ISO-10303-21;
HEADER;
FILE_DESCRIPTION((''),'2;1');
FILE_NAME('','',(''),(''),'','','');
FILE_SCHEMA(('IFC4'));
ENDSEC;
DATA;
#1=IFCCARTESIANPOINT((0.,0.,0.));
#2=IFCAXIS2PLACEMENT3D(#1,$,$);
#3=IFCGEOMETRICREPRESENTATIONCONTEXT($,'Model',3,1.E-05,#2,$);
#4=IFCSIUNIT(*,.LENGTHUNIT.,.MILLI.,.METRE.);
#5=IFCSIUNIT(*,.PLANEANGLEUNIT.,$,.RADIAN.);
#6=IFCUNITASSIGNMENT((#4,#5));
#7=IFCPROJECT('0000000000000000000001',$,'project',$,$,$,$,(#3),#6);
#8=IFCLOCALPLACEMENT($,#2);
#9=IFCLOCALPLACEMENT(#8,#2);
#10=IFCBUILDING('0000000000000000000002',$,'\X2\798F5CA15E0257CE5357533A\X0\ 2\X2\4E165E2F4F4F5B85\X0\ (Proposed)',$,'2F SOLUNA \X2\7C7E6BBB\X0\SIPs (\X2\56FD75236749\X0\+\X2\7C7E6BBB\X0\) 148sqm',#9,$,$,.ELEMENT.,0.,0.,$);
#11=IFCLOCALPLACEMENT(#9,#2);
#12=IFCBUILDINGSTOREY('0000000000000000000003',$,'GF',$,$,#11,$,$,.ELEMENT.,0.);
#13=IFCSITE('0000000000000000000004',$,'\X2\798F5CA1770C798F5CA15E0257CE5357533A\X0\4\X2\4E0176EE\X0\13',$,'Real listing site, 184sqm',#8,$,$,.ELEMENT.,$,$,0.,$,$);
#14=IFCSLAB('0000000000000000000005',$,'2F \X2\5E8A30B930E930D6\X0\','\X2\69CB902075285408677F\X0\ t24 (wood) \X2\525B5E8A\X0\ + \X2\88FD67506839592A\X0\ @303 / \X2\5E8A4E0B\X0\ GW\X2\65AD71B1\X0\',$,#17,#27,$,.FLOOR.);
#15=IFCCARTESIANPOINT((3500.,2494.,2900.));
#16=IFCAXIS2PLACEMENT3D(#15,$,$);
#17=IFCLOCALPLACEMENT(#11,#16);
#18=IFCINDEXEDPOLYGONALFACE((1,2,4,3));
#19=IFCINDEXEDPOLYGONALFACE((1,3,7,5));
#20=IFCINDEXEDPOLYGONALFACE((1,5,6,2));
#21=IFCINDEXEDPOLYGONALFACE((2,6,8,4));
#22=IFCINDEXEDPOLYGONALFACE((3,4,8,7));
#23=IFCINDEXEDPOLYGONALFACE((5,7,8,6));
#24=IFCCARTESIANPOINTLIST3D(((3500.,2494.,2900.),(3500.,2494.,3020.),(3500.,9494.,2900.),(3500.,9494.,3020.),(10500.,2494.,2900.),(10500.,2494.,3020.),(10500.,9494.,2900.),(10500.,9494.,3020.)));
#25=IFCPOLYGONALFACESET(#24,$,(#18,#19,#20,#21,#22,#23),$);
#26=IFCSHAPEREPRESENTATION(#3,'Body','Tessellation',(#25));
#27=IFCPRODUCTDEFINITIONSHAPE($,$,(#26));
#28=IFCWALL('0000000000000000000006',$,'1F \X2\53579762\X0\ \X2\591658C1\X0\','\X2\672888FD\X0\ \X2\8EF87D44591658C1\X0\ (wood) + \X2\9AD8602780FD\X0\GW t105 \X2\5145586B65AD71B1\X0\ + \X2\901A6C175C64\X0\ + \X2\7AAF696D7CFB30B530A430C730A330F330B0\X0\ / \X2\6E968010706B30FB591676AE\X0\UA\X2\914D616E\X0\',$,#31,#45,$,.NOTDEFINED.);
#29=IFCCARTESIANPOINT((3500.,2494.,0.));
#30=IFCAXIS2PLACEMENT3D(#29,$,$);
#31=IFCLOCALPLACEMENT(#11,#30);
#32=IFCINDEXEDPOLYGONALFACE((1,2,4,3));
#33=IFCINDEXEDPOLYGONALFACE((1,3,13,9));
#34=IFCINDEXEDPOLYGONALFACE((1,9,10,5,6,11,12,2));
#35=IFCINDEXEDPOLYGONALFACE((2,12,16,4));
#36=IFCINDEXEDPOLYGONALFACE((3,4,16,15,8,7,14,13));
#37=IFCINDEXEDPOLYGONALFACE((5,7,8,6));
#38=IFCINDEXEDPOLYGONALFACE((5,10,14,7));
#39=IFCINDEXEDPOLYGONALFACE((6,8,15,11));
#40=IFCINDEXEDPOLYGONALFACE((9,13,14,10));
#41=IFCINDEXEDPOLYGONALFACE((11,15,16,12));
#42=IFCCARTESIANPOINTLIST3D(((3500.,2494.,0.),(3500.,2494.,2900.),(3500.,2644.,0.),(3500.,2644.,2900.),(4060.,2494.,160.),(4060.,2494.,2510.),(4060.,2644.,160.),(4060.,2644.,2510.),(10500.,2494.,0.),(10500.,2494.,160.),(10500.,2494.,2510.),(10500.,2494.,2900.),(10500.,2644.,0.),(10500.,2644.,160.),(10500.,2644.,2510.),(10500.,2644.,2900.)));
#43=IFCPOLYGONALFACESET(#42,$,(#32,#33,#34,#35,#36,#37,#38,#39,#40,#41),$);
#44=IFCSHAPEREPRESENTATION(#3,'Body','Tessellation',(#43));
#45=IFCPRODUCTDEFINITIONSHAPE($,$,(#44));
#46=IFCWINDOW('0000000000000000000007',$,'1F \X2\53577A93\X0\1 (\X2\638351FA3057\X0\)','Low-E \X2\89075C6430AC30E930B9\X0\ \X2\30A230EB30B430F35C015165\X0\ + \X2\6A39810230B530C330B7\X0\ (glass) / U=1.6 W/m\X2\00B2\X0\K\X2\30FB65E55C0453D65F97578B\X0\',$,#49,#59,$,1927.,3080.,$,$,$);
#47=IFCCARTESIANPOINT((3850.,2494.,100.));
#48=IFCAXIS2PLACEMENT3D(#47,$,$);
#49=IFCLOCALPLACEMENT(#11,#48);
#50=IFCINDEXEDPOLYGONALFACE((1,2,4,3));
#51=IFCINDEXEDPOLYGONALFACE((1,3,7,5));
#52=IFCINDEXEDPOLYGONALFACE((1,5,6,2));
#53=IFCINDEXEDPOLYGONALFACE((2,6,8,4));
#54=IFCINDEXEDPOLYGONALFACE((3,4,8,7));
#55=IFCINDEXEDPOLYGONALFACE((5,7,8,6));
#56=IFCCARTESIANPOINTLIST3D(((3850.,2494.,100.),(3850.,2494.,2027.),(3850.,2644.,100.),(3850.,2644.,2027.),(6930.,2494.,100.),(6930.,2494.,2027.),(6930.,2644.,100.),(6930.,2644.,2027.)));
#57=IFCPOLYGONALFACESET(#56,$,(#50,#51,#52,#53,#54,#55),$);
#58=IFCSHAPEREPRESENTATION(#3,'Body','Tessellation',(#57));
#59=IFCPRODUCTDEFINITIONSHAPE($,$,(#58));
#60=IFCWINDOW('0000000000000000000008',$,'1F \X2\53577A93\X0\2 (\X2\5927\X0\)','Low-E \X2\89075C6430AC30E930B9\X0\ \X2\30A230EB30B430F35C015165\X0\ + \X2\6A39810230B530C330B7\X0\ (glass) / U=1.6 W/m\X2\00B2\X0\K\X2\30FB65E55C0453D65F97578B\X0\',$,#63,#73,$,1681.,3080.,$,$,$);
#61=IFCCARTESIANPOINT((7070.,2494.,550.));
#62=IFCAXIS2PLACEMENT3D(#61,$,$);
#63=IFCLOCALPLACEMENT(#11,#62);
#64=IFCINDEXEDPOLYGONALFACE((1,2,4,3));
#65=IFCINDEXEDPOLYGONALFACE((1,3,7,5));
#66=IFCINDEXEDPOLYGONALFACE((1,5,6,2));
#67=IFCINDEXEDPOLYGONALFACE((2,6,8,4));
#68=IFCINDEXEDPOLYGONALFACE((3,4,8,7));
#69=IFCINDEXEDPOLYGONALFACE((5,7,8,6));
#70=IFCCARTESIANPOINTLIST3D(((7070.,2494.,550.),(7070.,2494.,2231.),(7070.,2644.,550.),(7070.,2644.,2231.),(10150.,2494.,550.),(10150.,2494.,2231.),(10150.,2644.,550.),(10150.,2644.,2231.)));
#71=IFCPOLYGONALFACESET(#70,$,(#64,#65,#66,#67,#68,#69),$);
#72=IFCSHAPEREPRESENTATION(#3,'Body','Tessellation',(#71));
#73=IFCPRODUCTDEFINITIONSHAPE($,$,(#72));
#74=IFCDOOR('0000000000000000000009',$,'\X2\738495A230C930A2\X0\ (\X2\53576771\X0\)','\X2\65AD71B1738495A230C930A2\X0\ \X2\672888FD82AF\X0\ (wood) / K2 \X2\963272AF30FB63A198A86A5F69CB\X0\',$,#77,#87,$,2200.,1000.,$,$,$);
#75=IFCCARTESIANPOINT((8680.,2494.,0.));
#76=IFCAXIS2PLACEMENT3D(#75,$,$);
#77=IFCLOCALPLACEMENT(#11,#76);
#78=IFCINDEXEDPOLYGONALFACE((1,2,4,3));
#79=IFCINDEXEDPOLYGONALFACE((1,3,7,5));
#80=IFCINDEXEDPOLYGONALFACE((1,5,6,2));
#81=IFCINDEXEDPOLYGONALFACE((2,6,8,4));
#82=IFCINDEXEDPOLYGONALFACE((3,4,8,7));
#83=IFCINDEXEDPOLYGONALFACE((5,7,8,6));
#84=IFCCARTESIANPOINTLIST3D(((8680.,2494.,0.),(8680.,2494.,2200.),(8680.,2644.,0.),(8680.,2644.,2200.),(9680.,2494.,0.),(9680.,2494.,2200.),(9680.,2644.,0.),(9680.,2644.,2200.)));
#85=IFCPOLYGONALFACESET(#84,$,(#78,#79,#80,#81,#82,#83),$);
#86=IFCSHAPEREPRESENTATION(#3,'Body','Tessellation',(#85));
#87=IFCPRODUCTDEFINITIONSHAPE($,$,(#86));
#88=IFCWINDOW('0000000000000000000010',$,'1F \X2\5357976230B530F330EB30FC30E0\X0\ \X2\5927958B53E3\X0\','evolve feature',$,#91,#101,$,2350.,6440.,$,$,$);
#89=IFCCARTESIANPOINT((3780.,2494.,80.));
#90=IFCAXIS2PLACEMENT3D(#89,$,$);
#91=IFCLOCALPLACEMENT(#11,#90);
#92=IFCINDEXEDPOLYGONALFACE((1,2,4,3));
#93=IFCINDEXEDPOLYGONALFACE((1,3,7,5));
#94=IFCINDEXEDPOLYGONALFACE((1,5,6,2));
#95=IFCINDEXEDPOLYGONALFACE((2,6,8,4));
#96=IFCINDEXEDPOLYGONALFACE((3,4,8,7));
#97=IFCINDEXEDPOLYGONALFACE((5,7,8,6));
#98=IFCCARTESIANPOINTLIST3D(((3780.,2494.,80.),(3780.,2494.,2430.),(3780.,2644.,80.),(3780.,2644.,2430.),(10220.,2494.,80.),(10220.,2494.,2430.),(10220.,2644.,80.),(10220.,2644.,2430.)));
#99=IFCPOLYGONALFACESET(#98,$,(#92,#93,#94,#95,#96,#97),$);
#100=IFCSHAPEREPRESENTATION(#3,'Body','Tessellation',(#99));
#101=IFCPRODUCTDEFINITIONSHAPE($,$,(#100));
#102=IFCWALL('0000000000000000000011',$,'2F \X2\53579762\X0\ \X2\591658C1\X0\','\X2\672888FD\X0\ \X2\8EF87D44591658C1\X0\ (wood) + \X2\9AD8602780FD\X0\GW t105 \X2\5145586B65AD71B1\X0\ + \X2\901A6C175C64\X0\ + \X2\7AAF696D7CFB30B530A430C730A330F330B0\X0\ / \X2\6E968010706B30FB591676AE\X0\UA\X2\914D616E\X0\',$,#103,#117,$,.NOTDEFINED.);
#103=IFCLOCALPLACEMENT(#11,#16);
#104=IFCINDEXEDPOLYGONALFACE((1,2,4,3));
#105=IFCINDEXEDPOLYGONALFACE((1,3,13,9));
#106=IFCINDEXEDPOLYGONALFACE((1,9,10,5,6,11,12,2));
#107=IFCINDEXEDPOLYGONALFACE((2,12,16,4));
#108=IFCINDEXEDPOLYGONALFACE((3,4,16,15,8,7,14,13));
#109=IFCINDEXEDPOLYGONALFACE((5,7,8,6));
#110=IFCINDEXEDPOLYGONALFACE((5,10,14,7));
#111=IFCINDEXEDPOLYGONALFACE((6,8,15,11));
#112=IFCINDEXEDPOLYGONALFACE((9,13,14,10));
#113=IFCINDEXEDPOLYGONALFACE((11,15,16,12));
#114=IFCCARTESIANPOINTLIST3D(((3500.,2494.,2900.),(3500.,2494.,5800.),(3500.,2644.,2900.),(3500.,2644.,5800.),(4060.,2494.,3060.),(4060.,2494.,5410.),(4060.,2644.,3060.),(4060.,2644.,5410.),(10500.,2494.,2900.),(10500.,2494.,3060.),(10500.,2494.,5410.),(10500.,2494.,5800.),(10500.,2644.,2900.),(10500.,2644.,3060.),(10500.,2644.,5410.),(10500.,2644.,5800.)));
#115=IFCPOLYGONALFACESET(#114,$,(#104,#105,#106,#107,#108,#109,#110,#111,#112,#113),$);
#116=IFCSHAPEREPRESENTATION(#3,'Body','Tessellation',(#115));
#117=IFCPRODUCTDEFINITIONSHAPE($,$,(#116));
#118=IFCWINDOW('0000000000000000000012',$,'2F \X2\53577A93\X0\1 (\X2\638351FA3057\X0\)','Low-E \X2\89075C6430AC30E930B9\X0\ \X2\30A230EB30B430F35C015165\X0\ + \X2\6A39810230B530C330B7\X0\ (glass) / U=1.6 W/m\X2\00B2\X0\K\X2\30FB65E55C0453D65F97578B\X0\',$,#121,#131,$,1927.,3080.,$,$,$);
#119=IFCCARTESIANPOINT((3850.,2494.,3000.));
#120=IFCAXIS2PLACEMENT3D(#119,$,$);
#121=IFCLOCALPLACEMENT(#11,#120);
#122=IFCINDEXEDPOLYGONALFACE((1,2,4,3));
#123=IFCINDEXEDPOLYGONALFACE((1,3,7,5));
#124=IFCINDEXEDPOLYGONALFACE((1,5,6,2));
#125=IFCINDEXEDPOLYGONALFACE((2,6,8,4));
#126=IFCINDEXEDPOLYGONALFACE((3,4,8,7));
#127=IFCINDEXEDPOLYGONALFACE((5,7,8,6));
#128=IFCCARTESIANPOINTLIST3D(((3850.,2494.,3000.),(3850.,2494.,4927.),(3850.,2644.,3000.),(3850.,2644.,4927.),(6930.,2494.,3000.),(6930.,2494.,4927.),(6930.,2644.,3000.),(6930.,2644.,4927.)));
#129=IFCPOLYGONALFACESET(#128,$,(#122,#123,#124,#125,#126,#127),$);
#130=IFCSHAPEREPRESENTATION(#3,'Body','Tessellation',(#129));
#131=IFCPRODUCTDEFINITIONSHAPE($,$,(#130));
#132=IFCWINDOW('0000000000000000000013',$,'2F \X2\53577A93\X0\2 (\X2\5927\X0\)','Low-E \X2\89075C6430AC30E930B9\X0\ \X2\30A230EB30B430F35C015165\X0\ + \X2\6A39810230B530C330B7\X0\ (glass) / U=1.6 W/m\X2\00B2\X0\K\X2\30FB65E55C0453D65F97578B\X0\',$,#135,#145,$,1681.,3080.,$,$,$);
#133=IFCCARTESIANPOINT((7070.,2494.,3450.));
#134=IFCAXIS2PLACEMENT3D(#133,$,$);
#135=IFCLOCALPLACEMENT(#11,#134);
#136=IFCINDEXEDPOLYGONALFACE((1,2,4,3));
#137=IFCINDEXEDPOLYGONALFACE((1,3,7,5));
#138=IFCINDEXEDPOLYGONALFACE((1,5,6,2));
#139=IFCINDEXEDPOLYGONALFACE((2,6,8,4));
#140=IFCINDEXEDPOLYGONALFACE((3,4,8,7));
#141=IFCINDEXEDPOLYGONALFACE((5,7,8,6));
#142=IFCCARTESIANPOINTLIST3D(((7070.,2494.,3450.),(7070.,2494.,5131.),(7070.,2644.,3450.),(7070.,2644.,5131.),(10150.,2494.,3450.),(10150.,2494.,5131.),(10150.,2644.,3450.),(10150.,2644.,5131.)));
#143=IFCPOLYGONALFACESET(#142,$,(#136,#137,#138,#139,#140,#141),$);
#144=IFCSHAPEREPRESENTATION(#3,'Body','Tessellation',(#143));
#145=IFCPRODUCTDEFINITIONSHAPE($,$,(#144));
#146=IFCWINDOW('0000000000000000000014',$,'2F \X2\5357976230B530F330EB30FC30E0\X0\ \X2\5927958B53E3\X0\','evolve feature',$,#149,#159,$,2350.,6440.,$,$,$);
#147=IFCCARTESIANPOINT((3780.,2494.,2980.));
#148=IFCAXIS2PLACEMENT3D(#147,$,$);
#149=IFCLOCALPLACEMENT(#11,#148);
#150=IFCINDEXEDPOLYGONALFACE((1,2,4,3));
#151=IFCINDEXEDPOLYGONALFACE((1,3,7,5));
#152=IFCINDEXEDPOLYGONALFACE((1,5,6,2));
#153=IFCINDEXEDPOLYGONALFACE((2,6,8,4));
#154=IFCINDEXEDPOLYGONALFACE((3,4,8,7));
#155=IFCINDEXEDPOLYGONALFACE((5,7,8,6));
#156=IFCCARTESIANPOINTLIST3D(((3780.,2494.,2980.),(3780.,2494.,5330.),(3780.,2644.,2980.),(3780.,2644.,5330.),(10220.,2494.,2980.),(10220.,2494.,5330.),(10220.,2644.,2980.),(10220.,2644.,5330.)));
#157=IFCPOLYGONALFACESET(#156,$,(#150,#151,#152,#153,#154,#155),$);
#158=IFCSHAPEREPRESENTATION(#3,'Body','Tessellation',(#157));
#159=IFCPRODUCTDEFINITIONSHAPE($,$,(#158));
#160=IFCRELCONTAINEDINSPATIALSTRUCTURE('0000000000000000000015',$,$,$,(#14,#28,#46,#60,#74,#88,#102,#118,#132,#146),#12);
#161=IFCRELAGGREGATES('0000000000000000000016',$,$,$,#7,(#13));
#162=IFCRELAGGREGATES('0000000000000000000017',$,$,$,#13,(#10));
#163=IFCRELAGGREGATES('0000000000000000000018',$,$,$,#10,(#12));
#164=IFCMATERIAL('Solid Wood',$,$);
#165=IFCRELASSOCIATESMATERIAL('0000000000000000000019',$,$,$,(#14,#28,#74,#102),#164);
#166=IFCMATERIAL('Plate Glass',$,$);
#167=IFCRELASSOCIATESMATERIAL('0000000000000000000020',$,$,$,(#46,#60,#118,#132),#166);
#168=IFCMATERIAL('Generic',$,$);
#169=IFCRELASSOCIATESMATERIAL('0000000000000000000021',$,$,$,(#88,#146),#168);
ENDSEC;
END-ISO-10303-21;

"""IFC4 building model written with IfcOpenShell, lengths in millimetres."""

from ifc_helpers import new_model, si_unit, frame, frame_2d, origin, place, context, project, spatial, rectangle, extrude, material, element, fill, save


model = new_model("IFC4")

# Units and contexts
model_context = context("Model", 3, precision=1e-05, world=origin())
ifc_project = project(units=[si_unit("LENGTHUNIT", "METRE", prefix="MILLI"), si_unit("PLANEANGLEUNIT", "RADIAN")], contexts=[model_context])

# Site, building, storey
site_placement = place(None, origin())
site = spatial("IfcSite", under=ifc_project, at=site_placement, Name="福岡県福岡市城南区4丁目13", ObjectType="Real listing site, 184sqm", CompositionType="ELEMENT", RefElevation=0.0)
building_placement = place(site_placement, origin())
building = spatial("IfcBuilding", under=site, at=building_placement, Name="福岡市城南区 2世帯住宅 (Proposed)", ObjectType="2F SOLUNA 籾殻SIPs (国産杉+籾殻) 148sqm", CompositionType="ELEMENT", ElevationOfRefHeight=0.0, ElevationOfTerrain=0.0)
storey_placement = place(building_placement, origin())
storey = spatial("IfcBuildingStorey", under=building, at=storey_placement, Name="GF", CompositionType="ELEMENT", Elevation=0.0)

# Slab
ifc_material_1 = material(Name="Solid Wood")
slab_1_placement = place(storey_placement, frame((3500.0, 2494.0, 2900.0)))
element("IfcSlab", 1, at=slab_1_placement, inside=storey, material=ifc_material_1, Name="2F 床スラブ", Description="構造用合板 t24 (wood) 剛床 + 製材根太 @303 / 床下 GW断熱", PredefinedType="FLOOR", context=model_context, shape_type="SweptSolid", body=[
    extrude(rectangle(XDim=7000.0, YDim=7000.0, at=frame_2d((3500.0, 3500.0))), frame((3500.0, 2494.0, 2900.0)), (0.0, 0.0, 1.0), 120.0),
])
ifc_material_2 = material(Name="Generic")

# Wall, openings, windows, door
wall_1_placement = place(storey_placement, frame((3500.0, 2494.0, 0.0)))
wall_1 = element("IfcWall", 2, at=wall_1_placement, inside=storey, material=ifc_material_1, Name="1F 南面 外壁", Description="木製 軸組外壁 (wood) + 高性能GW t105 充填断熱 + 通気層 + 窯業系サイディング / 準耐火・外皮UA配慮", PredefinedType="NOTDEFINED", context=model_context, shape_type="SweptSolid", body=[
    extrude(rectangle(XDim=7000.0, YDim=150.0, at=frame_2d((3500.0, 75.0))), frame((3500.0, 2494.0, 0.0)), (0.0, 0.0, 1.0), 2900.0),
])
opening_1_placement = place(storey_placement, frame((3850.0, 2494.0, 100.0)))
opening_1 = element("IfcOpeningElement", 3, at=opening_1_placement, cuts=wall_1, PredefinedType="NOTDEFINED", context=model_context, shape_type="SweptSolid", body=[
    extrude(rectangle(XDim=3080.0, YDim=150.0, at=frame_2d((1540.0, 75.0))), frame((3850.0, 2494.0, 100.0)), (0.0, 0.0, 1.0), 1927.0),
])
opening_2_placement = place(storey_placement, frame((7070.0, 2494.0, 550.0)))
opening_2 = element("IfcOpeningElement", 4, at=opening_2_placement, cuts=wall_1, PredefinedType="NOTDEFINED", context=model_context, shape_type="SweptSolid", body=[
    extrude(rectangle(XDim=3080.0, YDim=150.0, at=frame_2d((1540.0, 75.0))), frame((7070.0, 2494.0, 550.0)), (0.0, 0.0, 1.0), 1681.0),
])
opening_3_placement = place(storey_placement, frame((8680.0, 2494.0, 0.0)))
opening_3 = element("IfcOpeningElement", 5, at=opening_3_placement, cuts=wall_1, PredefinedType="NOTDEFINED", context=model_context, shape_type="SweptSolid", body=[
    extrude(rectangle(XDim=1000.0, YDim=150.0, at=frame_2d((500.0, 75.0))), frame((8680.0, 2494.0, 0.0)), (0.0, 0.0, 1.0), 2200.0),
])
opening_4_placement = place(storey_placement, frame((3780.0, 2494.0, 80.0)))
opening_4 = element("IfcOpeningElement", 6, at=opening_4_placement, cuts=wall_1, PredefinedType="NOTDEFINED", context=model_context, shape_type="SweptSolid", body=[
    extrude(rectangle(XDim=6440.0, YDim=150.0, at=frame_2d((3220.0, 75.0))), frame((3780.0, 2494.0, 80.0)), (0.0, 0.0, 1.0), 2350.0),
])
ifc_material_3 = material(Name="Plate Glass")
window_1_placement = place(storey_placement, frame((3850.0, 2494.0, 100.0)))
window_1 = element("IfcWindow", 7, at=window_1_placement, inside=storey, material=ifc_material_3, Name="1F 南窓1 (掃出し)", Description="Low-E 複層ガラス アルゴン封入 + 樹脂サッシ (glass) / U=1.6 W/m²K・日射取得型", OverallHeight=1927.0, OverallWidth=3080.0, context=model_context, shape_type="SweptSolid", body=[
    extrude(rectangle(XDim=3080.0, YDim=150.0, at=frame_2d((1540.0, 75.0))), frame((3850.0, 2494.0, 100.0)), (0.0, 0.0, 1.0), 1927.0),
])
fill(opening_1, window_1)
window_2_placement = place(storey_placement, frame((7070.0, 2494.0, 550.0)))
window_2 = element("IfcWindow", 8, at=window_2_placement, inside=storey, material=ifc_material_3, Name="1F 南窓2 (大)", Description="Low-E 複層ガラス アルゴン封入 + 樹脂サッシ (glass) / U=1.6 W/m²K・日射取得型", OverallHeight=1681.0, OverallWidth=3080.0, context=model_context, shape_type="SweptSolid", body=[
    extrude(rectangle(XDim=3080.0, YDim=150.0, at=frame_2d((1540.0, 75.0))), frame((7070.0, 2494.0, 550.0)), (0.0, 0.0, 1.0), 1681.0),
])
fill(opening_2, window_2)
door_placement = place(storey_placement, frame((8680.0, 2494.0, 0.0)))
door = element("IfcDoor", 9, at=door_placement, inside=storey, material=ifc_material_1, Name="玄関ドア (南東)", Description="断熱玄関ドア 木製芯 (wood) / K2 防犯・採風機構", OverallHeight=2200.0, OverallWidth=1000.0, context=model_context, shape_type="SweptSolid", body=[
    extrude(rectangle(XDim=1000.0, YDim=150.0, at=frame_2d((500.0, 75.0))), frame((8680.0, 2494.0, 0.0)), (0.0, 0.0, 1.0), 2200.0),
])
fill(opening_3, door)
window_3_placement = place(storey_placement, frame((3780.0, 2494.0, 80.0)))
window_3 = element("IfcWindow", 10, at=window_3_placement, inside=storey, material=ifc_material_2, Name="1F 南面サンルーム 大開口", Description="evolve feature", OverallHeight=2350.0, OverallWidth=6440.0, context=model_context, shape_type="SweptSolid", body=[
    extrude(rectangle(XDim=6440.0, YDim=150.0, at=frame_2d((3220.0, 75.0))), frame((3780.0, 2494.0, 80.0)), (0.0, 0.0, 1.0), 2350.0),
])
fill(opening_4, window_3)

# Wall, openings, windows
wall_2_placement = place(storey_placement, frame((3500.0, 2494.0, 2900.0)))
wall_2 = element("IfcWall", 11, at=wall_2_placement, inside=storey, material=ifc_material_1, Name="2F 南面 外壁", Description="木製 軸組外壁 (wood) + 高性能GW t105 充填断熱 + 通気層 + 窯業系サイディング / 準耐火・外皮UA配慮", PredefinedType="NOTDEFINED", context=model_context, shape_type="SweptSolid", body=[
    extrude(rectangle(XDim=7000.0, YDim=150.0, at=frame_2d((3500.0, 75.0))), frame((3500.0, 2494.0, 2900.0)), (0.0, 0.0, 1.0), 2900.0),
])
opening_5_placement = place(storey_placement, frame((3850.0, 2494.0, 3000.0)))
opening_5 = element("IfcOpeningElement", 12, at=opening_5_placement, cuts=wall_2, PredefinedType="NOTDEFINED", context=model_context, shape_type="SweptSolid", body=[
    extrude(rectangle(XDim=3080.0, YDim=150.0, at=frame_2d((1540.0, 75.0))), frame((3850.0, 2494.0, 3000.0)), (0.0, 0.0, 1.0), 1927.0),
])
opening_6_placement = place(storey_placement, frame((7070.0, 2494.0, 3450.0)))
opening_6 = element("IfcOpeningElement", 13, at=opening_6_placement, cuts=wall_2, PredefinedType="NOTDEFINED", context=model_context, shape_type="SweptSolid", body=[
    extrude(rectangle(XDim=3080.0, YDim=150.0, at=frame_2d((1540.0, 75.0))), frame((7070.0, 2494.0, 3450.0)), (0.0, 0.0, 1.0), 1681.0),
])
opening_7_placement = place(storey_placement, frame((3780.0, 2494.0, 2980.0)))
opening_7 = element("IfcOpeningElement", 14, at=opening_7_placement, cuts=wall_2, PredefinedType="NOTDEFINED", context=model_context, shape_type="SweptSolid", body=[
    extrude(rectangle(XDim=6440.0, YDim=150.0, at=frame_2d((3220.0, 75.0))), frame((3780.0, 2494.0, 2980.0)), (0.0, 0.0, 1.0), 2350.0),
])
window_4_placement = place(storey_placement, frame((3850.0, 2494.0, 3000.0)))
window_4 = element("IfcWindow", 15, at=window_4_placement, inside=storey, material=ifc_material_3, Name="2F 南窓1 (掃出し)", Description="Low-E 複層ガラス アルゴン封入 + 樹脂サッシ (glass) / U=1.6 W/m²K・日射取得型", OverallHeight=1927.0, OverallWidth=3080.0, context=model_context, shape_type="SweptSolid", body=[
    extrude(rectangle(XDim=3080.0, YDim=150.0, at=frame_2d((1540.0, 75.0))), frame((3850.0, 2494.0, 3000.0)), (0.0, 0.0, 1.0), 1927.0),
])
fill(opening_5, window_4)
window_5_placement = place(storey_placement, frame((7070.0, 2494.0, 3450.0)))
window_5 = element("IfcWindow", 16, at=window_5_placement, inside=storey, material=ifc_material_3, Name="2F 南窓2 (大)", Description="Low-E 複層ガラス アルゴン封入 + 樹脂サッシ (glass) / U=1.6 W/m²K・日射取得型", OverallHeight=1681.0, OverallWidth=3080.0, context=model_context, shape_type="SweptSolid", body=[
    extrude(rectangle(XDim=3080.0, YDim=150.0, at=frame_2d((1540.0, 75.0))), frame((7070.0, 2494.0, 3450.0)), (0.0, 0.0, 1.0), 1681.0),
])
fill(opening_6, window_5)
window_6_placement = place(storey_placement, frame((3780.0, 2494.0, 2980.0)))
window_6 = element("IfcWindow", 17, at=window_6_placement, inside=storey, material=ifc_material_2, Name="2F 南面サンルーム 大開口", Description="evolve feature", OverallHeight=2350.0, OverallWidth=6440.0, context=model_context, shape_type="SweptSolid", body=[
    extrude(rectangle(XDim=6440.0, YDim=150.0, at=frame_2d((3220.0, 75.0))), frame((3780.0, 2494.0, 2980.0)), (0.0, 0.0, 1.0), 2350.0),
])
fill(opening_7, window_6)

save(model, "model.ifc")
